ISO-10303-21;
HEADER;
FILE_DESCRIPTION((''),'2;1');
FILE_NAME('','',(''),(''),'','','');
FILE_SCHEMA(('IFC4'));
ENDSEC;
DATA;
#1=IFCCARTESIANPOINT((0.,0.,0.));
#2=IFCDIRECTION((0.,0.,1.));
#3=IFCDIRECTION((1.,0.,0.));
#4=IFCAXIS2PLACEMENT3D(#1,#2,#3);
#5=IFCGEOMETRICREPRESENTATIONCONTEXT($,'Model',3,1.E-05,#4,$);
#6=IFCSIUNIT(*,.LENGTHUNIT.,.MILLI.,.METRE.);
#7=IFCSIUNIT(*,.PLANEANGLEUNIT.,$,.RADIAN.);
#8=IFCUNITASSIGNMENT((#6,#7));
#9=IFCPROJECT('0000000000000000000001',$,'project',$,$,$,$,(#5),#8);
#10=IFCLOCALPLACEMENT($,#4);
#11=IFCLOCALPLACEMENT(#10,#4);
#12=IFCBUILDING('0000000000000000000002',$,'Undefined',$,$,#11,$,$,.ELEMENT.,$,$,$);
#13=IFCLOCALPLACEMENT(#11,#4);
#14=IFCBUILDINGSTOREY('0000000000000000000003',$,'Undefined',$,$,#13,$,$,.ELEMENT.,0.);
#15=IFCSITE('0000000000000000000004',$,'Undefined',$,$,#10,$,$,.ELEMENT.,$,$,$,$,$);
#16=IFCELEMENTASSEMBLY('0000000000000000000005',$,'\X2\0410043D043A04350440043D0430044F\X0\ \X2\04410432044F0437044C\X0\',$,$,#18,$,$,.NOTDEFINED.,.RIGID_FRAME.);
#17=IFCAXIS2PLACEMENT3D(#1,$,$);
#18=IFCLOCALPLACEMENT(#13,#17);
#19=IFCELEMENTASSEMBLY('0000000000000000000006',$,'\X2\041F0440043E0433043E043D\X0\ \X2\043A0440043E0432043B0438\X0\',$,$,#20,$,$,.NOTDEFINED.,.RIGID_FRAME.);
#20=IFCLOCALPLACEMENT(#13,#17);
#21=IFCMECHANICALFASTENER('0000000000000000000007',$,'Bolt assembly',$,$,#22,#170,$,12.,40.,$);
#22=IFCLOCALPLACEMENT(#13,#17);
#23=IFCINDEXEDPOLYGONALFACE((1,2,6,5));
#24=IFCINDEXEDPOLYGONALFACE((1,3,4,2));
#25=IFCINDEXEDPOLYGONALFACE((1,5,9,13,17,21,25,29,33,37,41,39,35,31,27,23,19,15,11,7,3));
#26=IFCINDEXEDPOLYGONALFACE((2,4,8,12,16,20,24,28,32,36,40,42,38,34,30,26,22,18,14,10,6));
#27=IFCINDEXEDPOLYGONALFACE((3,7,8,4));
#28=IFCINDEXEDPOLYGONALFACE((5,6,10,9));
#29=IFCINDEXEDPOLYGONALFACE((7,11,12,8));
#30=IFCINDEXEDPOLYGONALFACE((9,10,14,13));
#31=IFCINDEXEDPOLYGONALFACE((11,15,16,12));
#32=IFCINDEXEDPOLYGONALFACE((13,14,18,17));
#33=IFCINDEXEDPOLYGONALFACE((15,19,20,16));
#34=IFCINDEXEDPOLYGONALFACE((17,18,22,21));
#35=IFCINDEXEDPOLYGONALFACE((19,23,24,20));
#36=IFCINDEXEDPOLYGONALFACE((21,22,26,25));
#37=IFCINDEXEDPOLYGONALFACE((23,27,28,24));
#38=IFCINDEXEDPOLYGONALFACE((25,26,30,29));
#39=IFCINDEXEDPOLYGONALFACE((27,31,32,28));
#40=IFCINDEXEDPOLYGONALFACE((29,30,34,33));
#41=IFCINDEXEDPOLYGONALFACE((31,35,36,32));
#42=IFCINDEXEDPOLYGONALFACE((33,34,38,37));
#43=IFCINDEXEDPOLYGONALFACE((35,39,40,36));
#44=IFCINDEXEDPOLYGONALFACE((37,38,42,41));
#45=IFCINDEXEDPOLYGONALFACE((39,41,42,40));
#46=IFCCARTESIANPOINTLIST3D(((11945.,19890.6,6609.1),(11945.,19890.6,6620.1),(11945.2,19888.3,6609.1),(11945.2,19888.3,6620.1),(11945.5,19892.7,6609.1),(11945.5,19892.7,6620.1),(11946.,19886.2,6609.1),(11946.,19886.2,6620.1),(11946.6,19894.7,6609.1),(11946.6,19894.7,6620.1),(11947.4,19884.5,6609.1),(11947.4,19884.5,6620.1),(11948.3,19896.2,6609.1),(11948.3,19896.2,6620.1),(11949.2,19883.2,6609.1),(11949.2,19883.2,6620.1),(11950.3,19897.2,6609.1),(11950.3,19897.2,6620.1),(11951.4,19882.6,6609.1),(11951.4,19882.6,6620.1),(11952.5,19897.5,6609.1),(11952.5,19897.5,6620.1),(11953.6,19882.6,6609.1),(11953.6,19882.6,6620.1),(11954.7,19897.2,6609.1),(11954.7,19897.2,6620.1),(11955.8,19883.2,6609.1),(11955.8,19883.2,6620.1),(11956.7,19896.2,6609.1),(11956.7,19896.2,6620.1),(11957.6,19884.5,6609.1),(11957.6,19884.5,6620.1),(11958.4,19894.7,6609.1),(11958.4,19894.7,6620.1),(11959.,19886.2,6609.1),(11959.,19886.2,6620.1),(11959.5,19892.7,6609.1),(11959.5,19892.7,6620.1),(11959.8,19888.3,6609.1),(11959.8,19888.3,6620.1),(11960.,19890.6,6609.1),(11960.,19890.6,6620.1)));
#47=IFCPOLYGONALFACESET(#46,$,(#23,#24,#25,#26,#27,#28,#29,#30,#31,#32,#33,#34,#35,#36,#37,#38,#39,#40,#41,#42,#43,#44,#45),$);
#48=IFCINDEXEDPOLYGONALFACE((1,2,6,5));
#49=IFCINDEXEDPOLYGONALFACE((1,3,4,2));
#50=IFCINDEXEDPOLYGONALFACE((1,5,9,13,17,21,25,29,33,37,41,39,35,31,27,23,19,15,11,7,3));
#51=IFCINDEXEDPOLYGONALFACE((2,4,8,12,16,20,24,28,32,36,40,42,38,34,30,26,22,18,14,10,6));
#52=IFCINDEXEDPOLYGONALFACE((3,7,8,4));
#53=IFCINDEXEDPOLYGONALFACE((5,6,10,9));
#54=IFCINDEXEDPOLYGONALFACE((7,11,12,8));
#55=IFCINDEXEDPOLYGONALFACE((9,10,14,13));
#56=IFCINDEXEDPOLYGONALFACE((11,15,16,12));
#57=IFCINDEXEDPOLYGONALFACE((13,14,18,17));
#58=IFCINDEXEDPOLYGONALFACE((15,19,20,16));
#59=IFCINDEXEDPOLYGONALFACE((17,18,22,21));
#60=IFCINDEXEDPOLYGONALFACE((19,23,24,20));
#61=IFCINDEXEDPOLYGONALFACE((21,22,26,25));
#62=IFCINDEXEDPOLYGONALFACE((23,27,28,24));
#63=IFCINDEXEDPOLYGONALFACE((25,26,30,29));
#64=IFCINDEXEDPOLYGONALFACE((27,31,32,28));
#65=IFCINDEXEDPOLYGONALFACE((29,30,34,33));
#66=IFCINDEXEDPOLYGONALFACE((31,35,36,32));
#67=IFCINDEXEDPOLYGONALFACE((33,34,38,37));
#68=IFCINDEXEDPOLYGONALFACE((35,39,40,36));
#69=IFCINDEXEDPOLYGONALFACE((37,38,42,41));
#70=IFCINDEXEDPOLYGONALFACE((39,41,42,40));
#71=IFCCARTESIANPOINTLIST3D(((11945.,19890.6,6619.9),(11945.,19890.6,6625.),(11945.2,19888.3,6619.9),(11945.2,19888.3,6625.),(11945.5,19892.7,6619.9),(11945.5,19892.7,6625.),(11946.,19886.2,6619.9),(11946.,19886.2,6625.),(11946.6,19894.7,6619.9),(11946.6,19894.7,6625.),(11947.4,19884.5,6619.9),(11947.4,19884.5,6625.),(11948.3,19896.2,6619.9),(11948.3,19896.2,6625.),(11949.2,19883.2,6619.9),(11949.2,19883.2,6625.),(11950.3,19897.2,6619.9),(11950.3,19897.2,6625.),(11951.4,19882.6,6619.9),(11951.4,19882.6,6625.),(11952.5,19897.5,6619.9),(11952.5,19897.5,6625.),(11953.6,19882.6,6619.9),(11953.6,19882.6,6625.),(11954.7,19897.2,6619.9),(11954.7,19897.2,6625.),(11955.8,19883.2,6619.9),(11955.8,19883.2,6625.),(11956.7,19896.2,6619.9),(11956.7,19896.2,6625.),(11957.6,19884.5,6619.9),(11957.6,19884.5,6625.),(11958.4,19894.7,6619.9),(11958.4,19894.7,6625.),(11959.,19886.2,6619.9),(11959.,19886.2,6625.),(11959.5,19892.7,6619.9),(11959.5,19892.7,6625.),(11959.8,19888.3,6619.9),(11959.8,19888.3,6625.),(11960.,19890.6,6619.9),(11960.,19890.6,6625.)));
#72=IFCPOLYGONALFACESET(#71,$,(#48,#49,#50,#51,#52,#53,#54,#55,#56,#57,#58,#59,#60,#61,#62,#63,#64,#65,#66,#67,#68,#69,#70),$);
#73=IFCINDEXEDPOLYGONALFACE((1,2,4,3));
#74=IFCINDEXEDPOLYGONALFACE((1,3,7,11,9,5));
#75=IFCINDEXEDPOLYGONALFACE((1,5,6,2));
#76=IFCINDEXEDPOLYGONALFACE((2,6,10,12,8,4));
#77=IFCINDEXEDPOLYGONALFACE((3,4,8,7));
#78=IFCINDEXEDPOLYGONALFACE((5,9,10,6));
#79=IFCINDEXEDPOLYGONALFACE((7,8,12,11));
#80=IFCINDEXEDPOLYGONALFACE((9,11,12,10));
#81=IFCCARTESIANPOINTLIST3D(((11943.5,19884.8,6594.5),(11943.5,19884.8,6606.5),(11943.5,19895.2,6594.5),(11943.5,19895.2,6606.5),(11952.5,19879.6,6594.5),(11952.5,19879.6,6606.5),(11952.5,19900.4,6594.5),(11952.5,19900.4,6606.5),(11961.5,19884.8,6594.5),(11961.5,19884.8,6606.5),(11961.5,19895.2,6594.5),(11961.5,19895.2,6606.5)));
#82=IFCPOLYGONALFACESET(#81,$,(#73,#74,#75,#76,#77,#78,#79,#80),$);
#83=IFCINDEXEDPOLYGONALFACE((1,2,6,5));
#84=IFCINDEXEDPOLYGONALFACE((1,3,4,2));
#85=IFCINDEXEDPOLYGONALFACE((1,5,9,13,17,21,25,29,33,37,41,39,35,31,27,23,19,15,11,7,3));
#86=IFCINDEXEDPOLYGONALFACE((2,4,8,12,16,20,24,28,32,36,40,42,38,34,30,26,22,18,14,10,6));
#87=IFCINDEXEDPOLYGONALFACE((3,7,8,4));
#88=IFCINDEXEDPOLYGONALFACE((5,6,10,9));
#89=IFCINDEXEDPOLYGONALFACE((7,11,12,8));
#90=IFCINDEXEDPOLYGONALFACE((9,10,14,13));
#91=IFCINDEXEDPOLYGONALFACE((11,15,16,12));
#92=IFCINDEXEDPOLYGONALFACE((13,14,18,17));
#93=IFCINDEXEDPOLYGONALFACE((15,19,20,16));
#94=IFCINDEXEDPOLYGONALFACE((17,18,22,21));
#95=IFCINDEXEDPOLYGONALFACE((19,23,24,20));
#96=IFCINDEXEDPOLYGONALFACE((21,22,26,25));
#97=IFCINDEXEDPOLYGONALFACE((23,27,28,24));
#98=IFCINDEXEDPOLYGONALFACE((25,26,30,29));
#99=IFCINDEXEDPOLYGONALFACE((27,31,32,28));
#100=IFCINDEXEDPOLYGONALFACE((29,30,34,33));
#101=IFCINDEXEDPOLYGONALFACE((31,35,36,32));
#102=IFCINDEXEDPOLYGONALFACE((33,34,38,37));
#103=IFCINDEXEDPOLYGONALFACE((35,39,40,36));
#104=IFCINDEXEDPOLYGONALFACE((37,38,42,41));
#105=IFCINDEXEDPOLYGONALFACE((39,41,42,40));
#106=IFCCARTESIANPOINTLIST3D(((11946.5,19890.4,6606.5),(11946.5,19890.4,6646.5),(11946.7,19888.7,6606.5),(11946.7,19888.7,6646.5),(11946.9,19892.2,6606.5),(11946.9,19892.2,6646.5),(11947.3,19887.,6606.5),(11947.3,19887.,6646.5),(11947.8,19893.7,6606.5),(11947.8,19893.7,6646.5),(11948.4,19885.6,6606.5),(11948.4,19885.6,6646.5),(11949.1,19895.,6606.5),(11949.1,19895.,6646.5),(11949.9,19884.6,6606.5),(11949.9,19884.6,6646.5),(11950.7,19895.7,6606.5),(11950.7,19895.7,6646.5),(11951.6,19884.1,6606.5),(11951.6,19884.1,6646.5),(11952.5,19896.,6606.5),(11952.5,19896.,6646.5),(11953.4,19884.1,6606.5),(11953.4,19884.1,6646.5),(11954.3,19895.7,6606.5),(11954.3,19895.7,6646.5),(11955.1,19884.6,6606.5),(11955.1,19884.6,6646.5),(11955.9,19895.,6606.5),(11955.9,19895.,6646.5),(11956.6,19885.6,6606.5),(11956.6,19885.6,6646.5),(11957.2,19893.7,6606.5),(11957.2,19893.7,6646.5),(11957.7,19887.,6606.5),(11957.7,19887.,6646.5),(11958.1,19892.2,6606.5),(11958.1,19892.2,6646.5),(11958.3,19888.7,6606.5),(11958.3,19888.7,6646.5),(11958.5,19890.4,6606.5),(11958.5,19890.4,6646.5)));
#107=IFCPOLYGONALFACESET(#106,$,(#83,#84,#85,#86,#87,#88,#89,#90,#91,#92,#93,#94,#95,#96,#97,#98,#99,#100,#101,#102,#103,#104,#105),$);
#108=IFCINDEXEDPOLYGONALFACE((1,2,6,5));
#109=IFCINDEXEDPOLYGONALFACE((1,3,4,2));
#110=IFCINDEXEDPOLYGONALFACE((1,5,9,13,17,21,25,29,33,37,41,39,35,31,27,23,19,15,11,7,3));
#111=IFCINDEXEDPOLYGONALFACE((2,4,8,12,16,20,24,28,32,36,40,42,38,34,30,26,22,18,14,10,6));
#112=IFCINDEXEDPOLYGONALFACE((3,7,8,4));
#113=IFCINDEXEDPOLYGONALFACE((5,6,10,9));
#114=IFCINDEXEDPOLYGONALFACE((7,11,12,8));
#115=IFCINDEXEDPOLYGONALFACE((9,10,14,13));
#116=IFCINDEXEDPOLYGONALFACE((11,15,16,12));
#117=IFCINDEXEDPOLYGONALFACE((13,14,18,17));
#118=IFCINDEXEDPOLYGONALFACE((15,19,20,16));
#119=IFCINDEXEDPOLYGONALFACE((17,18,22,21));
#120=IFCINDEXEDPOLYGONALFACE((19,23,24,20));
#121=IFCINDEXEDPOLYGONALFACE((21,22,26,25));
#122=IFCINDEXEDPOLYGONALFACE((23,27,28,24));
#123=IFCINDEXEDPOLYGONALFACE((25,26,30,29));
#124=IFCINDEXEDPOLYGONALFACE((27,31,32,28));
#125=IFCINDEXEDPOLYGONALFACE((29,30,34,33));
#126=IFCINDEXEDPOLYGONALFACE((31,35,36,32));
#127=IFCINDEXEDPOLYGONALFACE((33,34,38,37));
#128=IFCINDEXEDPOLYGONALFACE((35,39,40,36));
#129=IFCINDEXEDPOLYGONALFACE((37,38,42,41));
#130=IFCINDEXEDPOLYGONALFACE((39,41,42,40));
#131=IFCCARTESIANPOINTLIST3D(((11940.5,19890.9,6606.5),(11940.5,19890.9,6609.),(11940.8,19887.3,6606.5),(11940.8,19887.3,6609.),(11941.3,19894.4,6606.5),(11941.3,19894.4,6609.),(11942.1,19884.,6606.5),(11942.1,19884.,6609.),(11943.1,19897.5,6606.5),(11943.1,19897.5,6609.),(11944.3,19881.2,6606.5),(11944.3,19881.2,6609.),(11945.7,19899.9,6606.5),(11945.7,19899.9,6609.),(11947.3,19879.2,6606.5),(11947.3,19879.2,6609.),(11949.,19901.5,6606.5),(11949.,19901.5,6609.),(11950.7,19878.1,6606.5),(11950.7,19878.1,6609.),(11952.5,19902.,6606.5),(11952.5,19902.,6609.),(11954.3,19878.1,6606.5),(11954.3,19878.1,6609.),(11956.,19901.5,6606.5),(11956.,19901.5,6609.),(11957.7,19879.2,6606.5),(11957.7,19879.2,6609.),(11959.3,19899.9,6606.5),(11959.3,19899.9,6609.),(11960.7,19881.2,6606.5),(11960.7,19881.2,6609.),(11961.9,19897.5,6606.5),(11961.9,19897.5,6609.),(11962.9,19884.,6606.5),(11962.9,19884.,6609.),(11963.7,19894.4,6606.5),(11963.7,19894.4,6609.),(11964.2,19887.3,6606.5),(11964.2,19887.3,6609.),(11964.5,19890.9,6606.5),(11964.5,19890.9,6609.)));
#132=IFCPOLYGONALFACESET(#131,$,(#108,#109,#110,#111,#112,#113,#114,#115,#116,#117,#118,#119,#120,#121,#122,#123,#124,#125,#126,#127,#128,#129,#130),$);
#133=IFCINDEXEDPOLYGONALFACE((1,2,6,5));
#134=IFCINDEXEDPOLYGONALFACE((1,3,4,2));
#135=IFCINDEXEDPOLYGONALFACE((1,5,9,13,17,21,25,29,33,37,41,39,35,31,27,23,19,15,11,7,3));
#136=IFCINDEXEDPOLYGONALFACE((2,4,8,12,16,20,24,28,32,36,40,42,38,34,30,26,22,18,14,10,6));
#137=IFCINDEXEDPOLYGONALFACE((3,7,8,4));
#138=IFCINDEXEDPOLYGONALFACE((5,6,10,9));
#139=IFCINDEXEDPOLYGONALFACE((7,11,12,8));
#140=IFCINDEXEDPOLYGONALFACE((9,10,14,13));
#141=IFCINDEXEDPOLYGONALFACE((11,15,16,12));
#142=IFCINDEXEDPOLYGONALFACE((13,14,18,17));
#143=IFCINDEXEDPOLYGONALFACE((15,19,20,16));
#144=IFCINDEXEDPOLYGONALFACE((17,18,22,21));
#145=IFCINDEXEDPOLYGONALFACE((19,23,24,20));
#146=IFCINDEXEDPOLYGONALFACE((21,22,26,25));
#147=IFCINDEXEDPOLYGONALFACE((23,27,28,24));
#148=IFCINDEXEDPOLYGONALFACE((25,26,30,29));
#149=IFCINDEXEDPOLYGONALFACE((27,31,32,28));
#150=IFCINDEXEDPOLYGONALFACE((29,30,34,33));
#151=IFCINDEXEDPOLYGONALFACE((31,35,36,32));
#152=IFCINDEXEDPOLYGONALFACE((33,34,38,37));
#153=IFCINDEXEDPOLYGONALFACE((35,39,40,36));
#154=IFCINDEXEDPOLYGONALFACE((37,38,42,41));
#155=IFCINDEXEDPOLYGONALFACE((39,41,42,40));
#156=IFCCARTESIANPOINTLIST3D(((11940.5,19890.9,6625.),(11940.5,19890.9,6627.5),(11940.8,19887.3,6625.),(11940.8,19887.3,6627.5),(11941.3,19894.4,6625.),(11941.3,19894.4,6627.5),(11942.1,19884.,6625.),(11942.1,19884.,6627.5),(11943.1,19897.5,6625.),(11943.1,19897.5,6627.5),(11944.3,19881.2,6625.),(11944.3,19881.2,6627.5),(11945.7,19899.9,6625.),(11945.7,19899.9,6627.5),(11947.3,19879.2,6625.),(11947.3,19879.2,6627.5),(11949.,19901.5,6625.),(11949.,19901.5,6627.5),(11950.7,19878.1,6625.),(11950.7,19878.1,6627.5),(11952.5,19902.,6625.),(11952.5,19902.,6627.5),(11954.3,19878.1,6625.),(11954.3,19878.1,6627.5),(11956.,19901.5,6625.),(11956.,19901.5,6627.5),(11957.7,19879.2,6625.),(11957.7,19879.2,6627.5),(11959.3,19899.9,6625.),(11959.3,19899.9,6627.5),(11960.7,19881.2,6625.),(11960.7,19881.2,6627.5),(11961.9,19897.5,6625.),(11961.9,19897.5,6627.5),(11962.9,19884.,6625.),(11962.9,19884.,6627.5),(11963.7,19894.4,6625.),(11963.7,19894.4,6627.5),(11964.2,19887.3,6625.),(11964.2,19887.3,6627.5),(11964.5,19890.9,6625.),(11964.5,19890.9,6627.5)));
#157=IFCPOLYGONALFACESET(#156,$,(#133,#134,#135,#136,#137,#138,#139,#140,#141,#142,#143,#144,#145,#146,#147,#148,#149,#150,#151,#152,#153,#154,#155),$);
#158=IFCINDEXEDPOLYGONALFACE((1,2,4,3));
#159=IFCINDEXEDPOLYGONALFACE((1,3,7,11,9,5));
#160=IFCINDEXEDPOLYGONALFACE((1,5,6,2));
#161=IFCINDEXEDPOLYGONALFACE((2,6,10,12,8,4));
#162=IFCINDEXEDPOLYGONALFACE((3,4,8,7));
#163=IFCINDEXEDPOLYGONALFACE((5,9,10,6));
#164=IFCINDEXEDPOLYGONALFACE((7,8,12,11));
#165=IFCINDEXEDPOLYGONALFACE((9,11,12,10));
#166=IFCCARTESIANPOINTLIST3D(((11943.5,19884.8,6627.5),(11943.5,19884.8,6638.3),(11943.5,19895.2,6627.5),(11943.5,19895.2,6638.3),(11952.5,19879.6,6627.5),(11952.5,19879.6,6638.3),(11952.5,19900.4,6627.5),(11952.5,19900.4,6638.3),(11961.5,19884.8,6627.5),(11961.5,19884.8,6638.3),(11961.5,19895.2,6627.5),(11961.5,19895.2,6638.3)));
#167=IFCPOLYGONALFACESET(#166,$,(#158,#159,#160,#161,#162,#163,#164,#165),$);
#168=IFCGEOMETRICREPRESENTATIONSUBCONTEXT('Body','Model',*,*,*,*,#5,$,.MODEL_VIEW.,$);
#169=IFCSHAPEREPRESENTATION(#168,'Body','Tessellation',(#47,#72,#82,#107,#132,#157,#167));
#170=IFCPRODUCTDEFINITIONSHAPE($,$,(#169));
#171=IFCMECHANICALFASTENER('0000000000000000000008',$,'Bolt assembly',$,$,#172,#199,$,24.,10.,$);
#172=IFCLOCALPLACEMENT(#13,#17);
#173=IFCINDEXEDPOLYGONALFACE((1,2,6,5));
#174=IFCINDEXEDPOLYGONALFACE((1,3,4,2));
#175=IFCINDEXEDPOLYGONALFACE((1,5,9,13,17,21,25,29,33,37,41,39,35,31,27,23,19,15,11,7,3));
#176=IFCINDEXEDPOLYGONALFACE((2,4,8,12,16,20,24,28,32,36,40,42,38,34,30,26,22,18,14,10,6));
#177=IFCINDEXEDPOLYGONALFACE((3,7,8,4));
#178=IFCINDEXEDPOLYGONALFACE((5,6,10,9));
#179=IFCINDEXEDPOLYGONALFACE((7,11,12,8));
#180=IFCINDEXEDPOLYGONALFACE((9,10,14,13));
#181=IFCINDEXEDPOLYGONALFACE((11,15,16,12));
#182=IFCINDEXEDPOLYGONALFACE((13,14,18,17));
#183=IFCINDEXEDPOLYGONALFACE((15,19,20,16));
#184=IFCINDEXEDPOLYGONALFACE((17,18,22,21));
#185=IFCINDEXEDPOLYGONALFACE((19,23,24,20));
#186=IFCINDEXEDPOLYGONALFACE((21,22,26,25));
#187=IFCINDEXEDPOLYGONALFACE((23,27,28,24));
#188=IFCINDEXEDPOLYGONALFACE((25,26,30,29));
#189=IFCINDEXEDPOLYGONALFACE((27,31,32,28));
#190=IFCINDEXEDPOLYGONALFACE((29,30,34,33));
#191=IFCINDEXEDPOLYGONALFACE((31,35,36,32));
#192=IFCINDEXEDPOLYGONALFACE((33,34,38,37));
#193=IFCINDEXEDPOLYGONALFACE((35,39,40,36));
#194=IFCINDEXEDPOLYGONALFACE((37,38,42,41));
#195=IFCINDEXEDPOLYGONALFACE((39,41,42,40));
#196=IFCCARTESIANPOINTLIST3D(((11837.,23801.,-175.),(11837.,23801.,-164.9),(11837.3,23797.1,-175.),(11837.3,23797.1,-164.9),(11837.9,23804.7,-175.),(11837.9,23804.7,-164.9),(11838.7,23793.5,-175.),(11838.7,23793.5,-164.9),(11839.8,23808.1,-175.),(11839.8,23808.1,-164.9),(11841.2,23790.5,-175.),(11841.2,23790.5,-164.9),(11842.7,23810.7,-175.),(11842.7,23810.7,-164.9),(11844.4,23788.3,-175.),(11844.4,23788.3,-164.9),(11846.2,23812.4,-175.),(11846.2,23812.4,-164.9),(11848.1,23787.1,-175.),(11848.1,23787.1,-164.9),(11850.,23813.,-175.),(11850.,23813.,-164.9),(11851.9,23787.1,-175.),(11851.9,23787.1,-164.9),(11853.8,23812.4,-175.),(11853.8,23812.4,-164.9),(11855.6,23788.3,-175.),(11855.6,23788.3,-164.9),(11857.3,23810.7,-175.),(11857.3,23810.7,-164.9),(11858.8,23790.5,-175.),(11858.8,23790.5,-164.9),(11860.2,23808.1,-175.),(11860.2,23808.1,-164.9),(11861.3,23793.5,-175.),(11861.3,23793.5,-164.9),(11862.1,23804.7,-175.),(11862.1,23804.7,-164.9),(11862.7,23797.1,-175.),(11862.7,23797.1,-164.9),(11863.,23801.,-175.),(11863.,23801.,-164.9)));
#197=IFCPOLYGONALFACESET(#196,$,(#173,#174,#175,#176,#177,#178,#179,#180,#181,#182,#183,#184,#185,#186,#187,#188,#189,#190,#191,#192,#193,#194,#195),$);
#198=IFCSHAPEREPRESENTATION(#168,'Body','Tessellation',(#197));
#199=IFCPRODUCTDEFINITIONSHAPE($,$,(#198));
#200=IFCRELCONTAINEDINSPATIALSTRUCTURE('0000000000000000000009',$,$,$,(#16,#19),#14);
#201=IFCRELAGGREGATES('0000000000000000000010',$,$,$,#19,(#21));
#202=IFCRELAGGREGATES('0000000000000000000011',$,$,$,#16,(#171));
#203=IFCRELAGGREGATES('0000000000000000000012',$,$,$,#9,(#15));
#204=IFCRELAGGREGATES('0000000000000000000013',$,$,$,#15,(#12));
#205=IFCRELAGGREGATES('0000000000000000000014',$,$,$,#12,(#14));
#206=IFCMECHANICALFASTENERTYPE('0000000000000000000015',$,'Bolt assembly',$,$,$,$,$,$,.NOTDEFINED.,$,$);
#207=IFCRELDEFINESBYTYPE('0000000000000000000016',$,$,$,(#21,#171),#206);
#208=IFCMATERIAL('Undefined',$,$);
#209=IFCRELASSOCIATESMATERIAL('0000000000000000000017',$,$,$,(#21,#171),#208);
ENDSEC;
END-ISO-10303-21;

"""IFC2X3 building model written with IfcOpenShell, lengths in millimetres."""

from ifc_helpers import new_model, si_unit, frame, origin_with_axes, origin_2d_with_axis, place, context, subcontext, project, spatial, polyline, circle, outline, extrude, source, transform, mapped, material, type_object, element, aggregate, save


model = new_model("IFC2X3")

# Units and contexts
model_context = context("Model", 3, precision=1e-05, world=origin_with_axes())
body_context = subcontext(model_context, "Body", "Model", "MODEL_VIEW")
ifc_project = project(units=[si_unit("LENGTHUNIT", "METRE", prefix="MILLI"), si_unit("PLANEANGLEUNIT", "RADIAN")], contexts=[model_context])

# Site, building, storey
site_placement = place(None, origin_with_axes())
site = spatial("IfcSite", under=ifc_project, at=site_placement, Name="Undefined", CompositionType="ELEMENT")
building_placement = place(site_placement, origin_with_axes())
building = spatial("IfcBuilding", under=site, at=building_placement, Name="Undefined", CompositionType="ELEMENT")
storey_placement = place(building_placement, origin_with_axes())
storey = spatial("IfcBuildingStorey", under=building, at=storey_placement, Name="Undefined", CompositionType="ELEMENT", Elevation=0.0)

# Element assembly
assembly_1_placement = place(storey_placement, origin_with_axes())
assembly_1 = element("IfcElementAssembly", 1, at=assembly_1_placement, inside=storey, Name="Анкерная связь", AssemblyPlace="NOTDEFINED", PredefinedType="RIGID_FRAME")

# Element assembly, mechanical fastener
ifc_material_1 = material(Name="Undefined")
mechanical_fastener_type = type_object("IfcMechanicalFastenerType", Name="Bolt assembly")
shared_shape_1 = source(origin_with_axes(), body_context, "Body", "SweptSolid", [
    extrude(circle(Radius=7.5, at=origin_2d_with_axis()), frame((0.0, -10.9, 0.0), z_axis=(0.0, 1.0, 0.0), x_axis=(1.0, 0.0, 0.0)), (0.0, 0.0, 1.0), 11.0),
    extrude(circle(Radius=7.5, at=origin_2d_with_axis()), frame((0.0, -0.1, 0.0), z_axis=(0.0, 1.0, 0.0), x_axis=(1.0, 0.0, 0.0)), (0.0, 0.0, 1.0), 5.1),
    extrude(outline(polyline([(10.4, 0.0), (5.2, 9.0), (-5.2, 9.0), (-10.4, 0.0), (-5.2, -9.0), (5.2, -9.0), (10.4, 0.0)])), frame((0.0, -25.5, 0.0), z_axis=(0.0, 1.0, 0.0), x_axis=(1.0, 0.0, 0.0)), (0.0, 0.0, 1.0), 12.0),
    extrude(circle(Radius=6.0, at=origin_2d_with_axis()), frame((0.0, -13.5, 0.0), z_axis=(0.0, 1.0, 0.0), x_axis=(1.0, 0.0, 0.0)), (0.0, 0.0, 1.0), 40.0),
    extrude(circle(Radius=12.0, at=origin_2d_with_axis()), frame((0.0, -13.5, 0.0), z_axis=(0.0, 1.0, 0.0), x_axis=(1.0, 0.0, 0.0)), (0.0, 0.0, 1.0), 2.5),
    extrude(circle(Radius=12.0, at=origin_2d_with_axis()), frame((0.0, 5.0, 0.0), z_axis=(0.0, 1.0, 0.0), x_axis=(1.0, 0.0, 0.0)), (0.0, 0.0, 1.0), 2.5),
    extrude(outline(polyline([(10.4, 0.0), (5.2, 9.0), (-5.2, 9.0), (-10.4, 0.0), (-5.2, -9.0), (5.2, -9.0), (10.4, 0.0)])), frame((0.0, 7.5, 0.0), z_axis=(0.0, 1.0, 0.0), x_axis=(1.0, 0.0, 0.0)), (0.0, 0.0, 1.0), 10.8),
])
assembly_2_placement = place(storey_placement, origin_with_axes())
assembly_2 = element("IfcElementAssembly", 2, at=assembly_2_placement, inside=storey, Name="Прогон кровли", AssemblyPlace="NOTDEFINED", PredefinedType="RIGID_FRAME")
mechanical_fastener_1_placement = place(assembly_2_placement, frame((11952.5, 19890.0, 6620.0), z_axis=(1.0, 0.0, 0.0), x_axis=(0.0, 1.0, 0.0)))
mechanical_fastener_1 = element("IfcMechanicalFastener", 3, at=mechanical_fastener_1_placement, type_object=mechanical_fastener_type, material=ifc_material_1, Name="Bolt assembly", NominalDiameter=12.0, NominalLength=40.0, context=body_context, shape_type="MappedRepresentation", body=[
    mapped(shared_shape_1, transform((0.0, 0.0, 0.0))),
])
aggregate(assembly_2, [mechanical_fastener_1])

# Mechanical fastener
shared_shape_2 = source(origin_with_axes(), body_context, "Body", "SweptSolid", [
    extrude(circle(Radius=13.0, at=origin_2d_with_axis()), frame((0.0, 0.0, 0.0), z_axis=(0.0, 1.0, 0.0), x_axis=(1.0, 0.0, 0.0)), (0.0, 0.0, 1.0), 10.1),
])
mechanical_fastener_2_placement = place(assembly_1_placement, frame((11850.0, 23800.0, -175.0), z_axis=(1.0, 0.0, 0.0), x_axis=(0.0, 1.0, 0.0)))
mechanical_fastener_2 = element("IfcMechanicalFastener", 4, at=mechanical_fastener_2_placement, type_object=mechanical_fastener_type, material=ifc_material_1, Name="Bolt assembly", NominalDiameter=24.0, NominalLength=10.0, context=body_context, shape_type="MappedRepresentation", body=[
    mapped(shared_shape_2, transform((0.0, 0.0, 0.0))),
])
aggregate(assembly_1, [mechanical_fastener_2])

save(model, "model.ifc")
